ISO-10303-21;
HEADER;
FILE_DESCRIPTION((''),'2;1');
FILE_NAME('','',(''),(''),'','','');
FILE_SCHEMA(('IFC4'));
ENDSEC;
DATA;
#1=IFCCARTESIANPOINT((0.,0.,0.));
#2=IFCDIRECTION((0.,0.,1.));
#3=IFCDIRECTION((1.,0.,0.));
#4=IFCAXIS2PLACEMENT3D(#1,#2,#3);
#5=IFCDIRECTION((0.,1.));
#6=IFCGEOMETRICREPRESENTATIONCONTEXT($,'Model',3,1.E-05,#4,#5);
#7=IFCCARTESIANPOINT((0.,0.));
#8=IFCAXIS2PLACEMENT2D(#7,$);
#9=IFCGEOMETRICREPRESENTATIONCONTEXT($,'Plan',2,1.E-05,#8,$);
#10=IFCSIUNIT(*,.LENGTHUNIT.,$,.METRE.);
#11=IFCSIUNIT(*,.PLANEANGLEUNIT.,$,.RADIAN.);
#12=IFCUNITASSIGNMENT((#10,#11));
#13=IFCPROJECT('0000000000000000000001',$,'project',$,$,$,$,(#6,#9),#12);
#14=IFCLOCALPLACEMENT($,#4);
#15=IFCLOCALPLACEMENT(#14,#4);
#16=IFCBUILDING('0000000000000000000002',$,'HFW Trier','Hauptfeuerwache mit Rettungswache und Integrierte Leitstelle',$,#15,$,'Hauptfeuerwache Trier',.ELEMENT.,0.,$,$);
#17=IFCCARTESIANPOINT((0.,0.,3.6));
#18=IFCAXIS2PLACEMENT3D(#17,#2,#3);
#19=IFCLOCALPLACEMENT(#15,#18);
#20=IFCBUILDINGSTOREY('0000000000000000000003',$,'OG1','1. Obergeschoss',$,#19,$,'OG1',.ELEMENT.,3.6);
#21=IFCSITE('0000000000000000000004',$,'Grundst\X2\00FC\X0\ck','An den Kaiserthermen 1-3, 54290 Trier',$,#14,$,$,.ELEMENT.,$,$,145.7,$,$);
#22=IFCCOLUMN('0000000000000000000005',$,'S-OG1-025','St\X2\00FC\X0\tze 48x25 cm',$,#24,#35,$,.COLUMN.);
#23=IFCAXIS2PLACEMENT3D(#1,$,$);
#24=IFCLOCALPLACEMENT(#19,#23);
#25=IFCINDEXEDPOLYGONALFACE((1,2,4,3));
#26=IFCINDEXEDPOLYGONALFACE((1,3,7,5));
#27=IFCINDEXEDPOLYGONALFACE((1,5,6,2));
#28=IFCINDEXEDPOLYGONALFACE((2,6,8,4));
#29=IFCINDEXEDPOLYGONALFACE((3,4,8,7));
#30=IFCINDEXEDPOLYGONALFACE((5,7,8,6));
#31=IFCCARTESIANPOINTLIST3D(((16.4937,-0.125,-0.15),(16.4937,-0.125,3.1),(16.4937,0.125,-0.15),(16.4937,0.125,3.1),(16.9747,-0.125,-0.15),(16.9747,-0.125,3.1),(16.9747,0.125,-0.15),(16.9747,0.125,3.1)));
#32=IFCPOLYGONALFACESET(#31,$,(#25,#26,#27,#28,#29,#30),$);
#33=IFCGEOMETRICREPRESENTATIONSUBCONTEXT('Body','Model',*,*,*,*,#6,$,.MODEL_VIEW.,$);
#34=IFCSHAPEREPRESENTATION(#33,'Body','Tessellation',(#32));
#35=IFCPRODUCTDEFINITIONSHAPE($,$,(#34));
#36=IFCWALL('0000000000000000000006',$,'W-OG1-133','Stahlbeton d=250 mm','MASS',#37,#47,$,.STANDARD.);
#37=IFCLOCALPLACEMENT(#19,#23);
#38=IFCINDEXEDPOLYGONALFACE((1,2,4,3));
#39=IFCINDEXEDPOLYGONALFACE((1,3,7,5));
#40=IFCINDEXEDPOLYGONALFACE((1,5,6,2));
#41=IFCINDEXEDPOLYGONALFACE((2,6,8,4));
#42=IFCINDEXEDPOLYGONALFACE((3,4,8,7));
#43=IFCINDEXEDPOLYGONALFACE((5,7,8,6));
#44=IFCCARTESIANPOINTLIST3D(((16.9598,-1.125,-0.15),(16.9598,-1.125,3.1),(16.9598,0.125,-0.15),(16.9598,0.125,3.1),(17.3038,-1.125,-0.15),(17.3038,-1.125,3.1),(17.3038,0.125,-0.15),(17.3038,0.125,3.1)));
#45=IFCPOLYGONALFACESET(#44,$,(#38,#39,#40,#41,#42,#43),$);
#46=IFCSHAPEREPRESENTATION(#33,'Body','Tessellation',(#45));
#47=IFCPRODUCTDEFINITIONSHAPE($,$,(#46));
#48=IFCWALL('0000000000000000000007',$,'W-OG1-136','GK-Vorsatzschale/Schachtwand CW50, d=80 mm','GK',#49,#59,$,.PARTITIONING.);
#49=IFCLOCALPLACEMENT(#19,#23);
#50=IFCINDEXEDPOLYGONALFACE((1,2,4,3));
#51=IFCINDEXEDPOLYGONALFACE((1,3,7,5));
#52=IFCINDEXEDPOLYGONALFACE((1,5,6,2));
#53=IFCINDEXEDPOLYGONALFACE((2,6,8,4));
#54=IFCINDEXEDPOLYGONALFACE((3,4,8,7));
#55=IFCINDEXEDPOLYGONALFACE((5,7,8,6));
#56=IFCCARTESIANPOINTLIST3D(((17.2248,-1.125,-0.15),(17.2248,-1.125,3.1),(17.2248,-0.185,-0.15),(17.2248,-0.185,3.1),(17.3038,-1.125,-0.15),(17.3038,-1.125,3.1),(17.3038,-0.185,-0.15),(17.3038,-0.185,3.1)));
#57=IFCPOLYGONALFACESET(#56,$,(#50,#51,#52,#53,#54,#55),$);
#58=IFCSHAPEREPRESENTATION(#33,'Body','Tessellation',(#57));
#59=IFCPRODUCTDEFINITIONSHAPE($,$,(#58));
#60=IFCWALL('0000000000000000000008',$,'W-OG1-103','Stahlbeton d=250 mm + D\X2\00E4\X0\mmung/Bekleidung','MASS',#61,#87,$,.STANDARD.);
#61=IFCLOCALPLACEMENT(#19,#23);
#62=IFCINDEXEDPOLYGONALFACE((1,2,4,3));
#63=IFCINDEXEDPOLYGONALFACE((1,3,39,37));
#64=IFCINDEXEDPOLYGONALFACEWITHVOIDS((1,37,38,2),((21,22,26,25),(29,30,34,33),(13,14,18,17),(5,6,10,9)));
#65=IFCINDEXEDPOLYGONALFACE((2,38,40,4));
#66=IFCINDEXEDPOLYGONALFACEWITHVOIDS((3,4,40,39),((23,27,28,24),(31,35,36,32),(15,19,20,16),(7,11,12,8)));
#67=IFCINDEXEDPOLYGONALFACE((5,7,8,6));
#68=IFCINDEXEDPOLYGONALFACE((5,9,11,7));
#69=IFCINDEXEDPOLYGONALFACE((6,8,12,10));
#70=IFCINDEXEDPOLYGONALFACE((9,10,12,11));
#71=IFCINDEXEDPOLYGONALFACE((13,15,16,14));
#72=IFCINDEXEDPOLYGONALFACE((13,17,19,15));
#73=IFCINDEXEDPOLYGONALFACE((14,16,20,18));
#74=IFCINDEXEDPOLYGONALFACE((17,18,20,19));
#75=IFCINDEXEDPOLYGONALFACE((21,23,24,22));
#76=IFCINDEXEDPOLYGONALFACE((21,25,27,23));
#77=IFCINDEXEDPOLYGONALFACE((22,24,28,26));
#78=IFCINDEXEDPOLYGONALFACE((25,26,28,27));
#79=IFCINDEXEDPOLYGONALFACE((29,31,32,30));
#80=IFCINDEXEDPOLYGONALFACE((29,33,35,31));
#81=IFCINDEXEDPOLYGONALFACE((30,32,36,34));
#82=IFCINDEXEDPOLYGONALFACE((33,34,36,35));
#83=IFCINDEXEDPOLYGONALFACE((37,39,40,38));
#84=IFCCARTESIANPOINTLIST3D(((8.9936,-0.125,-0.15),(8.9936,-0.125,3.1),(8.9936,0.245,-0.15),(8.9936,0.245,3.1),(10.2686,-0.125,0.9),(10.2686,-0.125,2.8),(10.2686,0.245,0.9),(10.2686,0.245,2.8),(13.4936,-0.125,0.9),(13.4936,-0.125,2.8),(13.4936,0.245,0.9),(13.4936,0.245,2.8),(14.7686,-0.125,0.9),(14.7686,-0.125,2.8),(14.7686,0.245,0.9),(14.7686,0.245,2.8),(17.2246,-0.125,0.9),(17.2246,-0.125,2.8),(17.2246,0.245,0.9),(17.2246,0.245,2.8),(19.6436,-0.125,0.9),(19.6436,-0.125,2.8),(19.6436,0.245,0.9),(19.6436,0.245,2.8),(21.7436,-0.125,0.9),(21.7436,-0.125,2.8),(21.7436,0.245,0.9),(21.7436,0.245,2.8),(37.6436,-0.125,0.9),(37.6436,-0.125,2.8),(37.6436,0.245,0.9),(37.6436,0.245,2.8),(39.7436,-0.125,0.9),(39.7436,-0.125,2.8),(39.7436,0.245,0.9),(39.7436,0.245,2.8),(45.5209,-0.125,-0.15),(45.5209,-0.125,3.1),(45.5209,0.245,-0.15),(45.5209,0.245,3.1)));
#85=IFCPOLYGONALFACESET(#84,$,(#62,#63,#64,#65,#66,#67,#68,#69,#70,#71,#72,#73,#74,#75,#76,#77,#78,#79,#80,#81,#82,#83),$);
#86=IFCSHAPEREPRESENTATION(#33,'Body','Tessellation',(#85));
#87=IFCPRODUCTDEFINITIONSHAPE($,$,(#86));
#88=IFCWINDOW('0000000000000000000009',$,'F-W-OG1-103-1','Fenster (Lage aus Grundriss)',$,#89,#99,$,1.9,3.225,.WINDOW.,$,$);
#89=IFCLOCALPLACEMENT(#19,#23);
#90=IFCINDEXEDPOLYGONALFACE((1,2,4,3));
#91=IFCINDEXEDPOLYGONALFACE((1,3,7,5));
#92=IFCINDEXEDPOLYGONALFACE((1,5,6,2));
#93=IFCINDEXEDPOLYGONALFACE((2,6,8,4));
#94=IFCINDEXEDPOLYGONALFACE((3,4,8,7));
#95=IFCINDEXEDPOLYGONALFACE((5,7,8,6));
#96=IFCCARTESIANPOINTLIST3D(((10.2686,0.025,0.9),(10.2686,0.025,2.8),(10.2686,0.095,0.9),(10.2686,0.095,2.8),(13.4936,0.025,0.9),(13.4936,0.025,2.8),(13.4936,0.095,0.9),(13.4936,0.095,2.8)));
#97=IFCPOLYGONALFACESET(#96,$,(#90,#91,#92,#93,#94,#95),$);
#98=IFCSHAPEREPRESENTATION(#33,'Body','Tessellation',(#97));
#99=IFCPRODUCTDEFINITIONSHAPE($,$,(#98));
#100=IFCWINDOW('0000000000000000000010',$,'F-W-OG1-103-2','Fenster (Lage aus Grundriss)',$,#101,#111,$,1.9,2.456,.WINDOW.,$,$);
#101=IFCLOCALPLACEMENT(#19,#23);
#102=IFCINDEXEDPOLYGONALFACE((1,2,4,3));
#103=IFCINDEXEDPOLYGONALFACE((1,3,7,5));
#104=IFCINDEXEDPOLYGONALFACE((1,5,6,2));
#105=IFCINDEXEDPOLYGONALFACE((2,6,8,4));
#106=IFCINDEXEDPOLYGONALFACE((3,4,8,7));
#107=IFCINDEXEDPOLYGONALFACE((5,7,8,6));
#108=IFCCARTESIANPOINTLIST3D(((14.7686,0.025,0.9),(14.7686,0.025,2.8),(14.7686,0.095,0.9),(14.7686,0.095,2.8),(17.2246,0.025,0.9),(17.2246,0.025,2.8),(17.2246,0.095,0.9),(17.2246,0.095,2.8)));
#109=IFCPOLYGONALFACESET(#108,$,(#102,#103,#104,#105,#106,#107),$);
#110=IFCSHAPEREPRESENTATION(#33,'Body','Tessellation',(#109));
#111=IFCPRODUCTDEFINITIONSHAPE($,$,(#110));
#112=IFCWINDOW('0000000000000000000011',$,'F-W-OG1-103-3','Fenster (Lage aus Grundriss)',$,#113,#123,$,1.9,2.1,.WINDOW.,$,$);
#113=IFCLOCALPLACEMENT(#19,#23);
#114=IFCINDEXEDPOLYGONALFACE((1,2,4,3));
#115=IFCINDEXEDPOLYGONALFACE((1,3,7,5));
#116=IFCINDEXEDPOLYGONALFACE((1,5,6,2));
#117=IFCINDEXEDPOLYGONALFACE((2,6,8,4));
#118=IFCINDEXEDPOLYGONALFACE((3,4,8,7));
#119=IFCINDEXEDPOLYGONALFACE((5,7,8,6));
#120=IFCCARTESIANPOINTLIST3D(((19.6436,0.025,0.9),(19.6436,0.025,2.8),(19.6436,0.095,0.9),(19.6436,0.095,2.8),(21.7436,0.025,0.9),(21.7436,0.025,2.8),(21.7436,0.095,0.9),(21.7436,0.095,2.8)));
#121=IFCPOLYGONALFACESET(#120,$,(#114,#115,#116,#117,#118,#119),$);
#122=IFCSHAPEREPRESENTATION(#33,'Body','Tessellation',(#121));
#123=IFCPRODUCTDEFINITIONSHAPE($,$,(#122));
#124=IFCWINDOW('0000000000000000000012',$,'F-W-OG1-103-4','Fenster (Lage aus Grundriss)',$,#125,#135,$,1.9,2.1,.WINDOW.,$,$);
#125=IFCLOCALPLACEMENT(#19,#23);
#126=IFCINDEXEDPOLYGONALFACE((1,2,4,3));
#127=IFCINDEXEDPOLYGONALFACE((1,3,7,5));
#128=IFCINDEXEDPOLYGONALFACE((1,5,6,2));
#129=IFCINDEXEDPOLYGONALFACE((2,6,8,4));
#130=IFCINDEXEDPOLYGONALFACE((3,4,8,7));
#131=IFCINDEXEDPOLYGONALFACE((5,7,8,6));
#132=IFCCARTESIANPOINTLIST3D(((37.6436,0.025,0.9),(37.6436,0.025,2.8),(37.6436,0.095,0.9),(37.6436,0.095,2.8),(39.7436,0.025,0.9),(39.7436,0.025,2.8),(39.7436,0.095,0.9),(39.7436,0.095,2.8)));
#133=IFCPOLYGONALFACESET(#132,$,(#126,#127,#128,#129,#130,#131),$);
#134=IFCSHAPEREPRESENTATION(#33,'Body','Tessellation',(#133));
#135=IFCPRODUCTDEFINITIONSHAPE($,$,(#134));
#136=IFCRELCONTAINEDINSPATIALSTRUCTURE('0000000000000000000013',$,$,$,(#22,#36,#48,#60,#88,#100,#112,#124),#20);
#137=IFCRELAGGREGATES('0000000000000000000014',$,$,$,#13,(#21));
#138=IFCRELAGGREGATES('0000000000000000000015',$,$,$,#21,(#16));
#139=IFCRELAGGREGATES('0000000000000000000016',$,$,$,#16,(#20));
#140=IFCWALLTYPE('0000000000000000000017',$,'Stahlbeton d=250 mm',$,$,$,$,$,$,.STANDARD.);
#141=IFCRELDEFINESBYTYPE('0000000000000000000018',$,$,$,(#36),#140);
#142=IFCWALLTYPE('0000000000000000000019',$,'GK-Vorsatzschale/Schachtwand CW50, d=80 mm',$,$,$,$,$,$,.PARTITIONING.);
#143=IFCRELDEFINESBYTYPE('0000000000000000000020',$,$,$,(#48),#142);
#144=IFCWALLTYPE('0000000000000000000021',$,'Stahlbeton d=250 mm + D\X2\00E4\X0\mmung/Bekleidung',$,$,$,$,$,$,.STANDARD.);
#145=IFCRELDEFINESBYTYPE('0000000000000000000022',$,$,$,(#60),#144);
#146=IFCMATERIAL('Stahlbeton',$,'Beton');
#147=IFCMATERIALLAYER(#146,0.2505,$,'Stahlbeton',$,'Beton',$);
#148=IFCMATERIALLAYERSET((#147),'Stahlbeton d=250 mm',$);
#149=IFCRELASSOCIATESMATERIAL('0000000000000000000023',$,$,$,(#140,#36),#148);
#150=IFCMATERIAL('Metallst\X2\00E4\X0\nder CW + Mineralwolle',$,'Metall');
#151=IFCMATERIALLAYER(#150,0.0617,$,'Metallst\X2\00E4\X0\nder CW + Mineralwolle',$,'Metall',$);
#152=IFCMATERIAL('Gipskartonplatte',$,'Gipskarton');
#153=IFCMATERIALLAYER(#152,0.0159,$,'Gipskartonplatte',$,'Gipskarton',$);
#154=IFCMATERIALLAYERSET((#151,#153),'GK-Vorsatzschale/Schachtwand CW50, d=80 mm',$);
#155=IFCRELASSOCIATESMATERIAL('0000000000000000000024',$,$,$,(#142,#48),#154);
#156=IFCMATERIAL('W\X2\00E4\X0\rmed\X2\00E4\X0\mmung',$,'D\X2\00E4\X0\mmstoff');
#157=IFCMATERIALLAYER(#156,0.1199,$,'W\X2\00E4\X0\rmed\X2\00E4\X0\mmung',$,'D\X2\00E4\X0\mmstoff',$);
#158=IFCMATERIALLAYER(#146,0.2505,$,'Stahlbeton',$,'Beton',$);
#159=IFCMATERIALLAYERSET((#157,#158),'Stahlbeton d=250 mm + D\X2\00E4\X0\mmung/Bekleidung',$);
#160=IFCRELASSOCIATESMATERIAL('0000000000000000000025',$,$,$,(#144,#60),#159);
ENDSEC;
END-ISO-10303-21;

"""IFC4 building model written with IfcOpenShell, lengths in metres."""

from ifc_helpers import new_model, si_unit, direction, frame, frame_2d, origin_with_axes, origin_2d, place, context, subcontext, project, spatial, rectangle, extrude, material, layer, layer_set, layer_usage, type_object, element, fill, save


model = new_model("IFC4")

# Units and contexts
model_context = context("Model", 3, precision=1e-05, world=origin_with_axes(), true_north=direction((0.0, 1.0)))
plan_context = context("Plan", 2, precision=1e-05, world=origin_2d())
body_context = subcontext(model_context, "Body", "Model", "MODEL_VIEW")
ifc_project = project(units=[si_unit("LENGTHUNIT", "METRE"), si_unit("PLANEANGLEUNIT", "RADIAN")], contexts=[model_context, plan_context])

# Site, building, storey
site_placement = place(None, origin_with_axes())
site = spatial("IfcSite", under=ifc_project, at=site_placement, Name="Grundstück", Description="An den Kaiserthermen 1-3, 54290 Trier", CompositionType="ELEMENT", RefElevation=145.7)
building_placement = place(site_placement, origin_with_axes())
building = spatial("IfcBuilding", under=site, at=building_placement, Name="HFW Trier", Description="Hauptfeuerwache mit Rettungswache und Integrierte Leitstelle", LongName="Hauptfeuerwache Trier", CompositionType="ELEMENT", ElevationOfRefHeight=0.0)
storey_placement = place(building_placement, frame((0.0, 0.0, 3.6), z_axis=(0.0, 0.0, 1.0), x_axis=(1.0, 0.0, 0.0)))
storey = spatial("IfcBuildingStorey", under=building, at=storey_placement, Name="OG1", Description="1. Obergeschoss", LongName="OG1", CompositionType="ELEMENT", Elevation=3.6)

# Column
column_placement = place(storey_placement, frame((16.4937, 0.0, -0.15), z_axis=(0.0, 0.0, 1.0), x_axis=(1.0, 0.0, 0.0)))
element("IfcColumn", 1, at=column_placement, inside=storey, Name="S-OG1-025", Description="Stütze 48x25 cm", PredefinedType="COLUMN", context=body_context, shape_type="SweptSolid", body=[
    extrude(rectangle(XDim=0.481, YDim=0.25, at=frame_2d((0.2405, 0.0))), origin_with_axes(), (0.0, 0.0, 1.0), 3.25),
])

# Walls
ifc_material_1 = material(Name="Stahlbeton", Category="Beton")
ifc_layer_1 = layer(ifc_material_1, 0.2505, Name="Stahlbeton", Category="Beton")
ifc_layer_set_1 = layer_set([ifc_layer_1], Name="Stahlbeton d=250 mm")
ifc_layer_usage_1 = layer_usage(ifc_layer_set_1, "AXIS2", "POSITIVE", -0.172)
wall_type_1 = type_object("IfcWallType", Name="Stahlbeton d=250 mm", PredefinedType="STANDARD", material=ifc_layer_set_1)
wall_1_placement = place(storey_placement, frame((17.1318, 0.125, -0.15), z_axis=(0.0, 0.0, 1.0), x_axis=(0.0, -1.0, 0.0)))
element("IfcWall", 2, at=wall_1_placement, inside=storey, type_object=wall_type_1, material=ifc_layer_usage_1, Name="W-OG1-133", Description="Stahlbeton d=250 mm", ObjectType="MASS", PredefinedType="STANDARD", context=body_context, shape_type="SweptSolid", body=[
    extrude(rectangle(XDim=1.25, YDim=0.344, at=frame_2d((0.625, 0.0))), origin_with_axes(), (0.0, 0.0, 1.0), 3.25),
])
ifc_material_2 = material(Name="Metallständer CW + Mineralwolle", Category="Metall")
ifc_layer_2 = layer(ifc_material_2, 0.0617, Name="Metallständer CW + Mineralwolle", Category="Metall")
ifc_material_3 = material(Name="Gipskartonplatte", Category="Gipskarton")
ifc_layer_3 = layer(ifc_material_3, 0.0159, Name="Gipskartonplatte", Category="Gipskarton")
ifc_layer_set_2 = layer_set([ifc_layer_2, ifc_layer_3], Name="GK-Vorsatzschale/Schachtwand CW50, d=80 mm")
ifc_layer_usage_2 = layer_usage(ifc_layer_set_2, "AXIS2", "POSITIVE", -0.0395)
wall_type_2 = type_object("IfcWallType", Name="GK-Vorsatzschale/Schachtwand CW50, d=80 mm", PredefinedType="PARTITIONING", material=ifc_layer_set_2)
wall_2_placement = place(storey_placement, frame((17.2643, -0.185, -0.15), z_axis=(0.0, 0.0, 1.0), x_axis=(0.0, -1.0, 0.0)))
element("IfcWall", 3, at=wall_2_placement, inside=storey, type_object=wall_type_2, material=ifc_layer_usage_2, Name="W-OG1-136", Description="GK-Vorsatzschale/Schachtwand CW50, d=80 mm", ObjectType="GK", PredefinedType="PARTITIONING", context=body_context, shape_type="SweptSolid", body=[
    extrude(rectangle(XDim=0.94, YDim=0.079, at=frame_2d((0.47, 0.0))), origin_with_axes(), (0.0, 0.0, 1.0), 3.25),
])

# Wall, openings, windows
ifc_material_4 = material(Name="Wärmedämmung", Category="Dämmstoff")
ifc_layer_4 = layer(ifc_material_4, 0.1199, Name="Wärmedämmung", Category="Dämmstoff")
ifc_layer_5 = layer(ifc_material_1, 0.2505, Name="Stahlbeton", Category="Beton")
ifc_layer_set_3 = layer_set([ifc_layer_4, ifc_layer_5], Name="Stahlbeton d=250 mm + Dämmung/Bekleidung")
ifc_layer_usage_3 = layer_usage(ifc_layer_set_3, "AXIS2", "POSITIVE", -0.185)
wall_type_3 = type_object("IfcWallType", Name="Stahlbeton d=250 mm + Dämmung/Bekleidung", PredefinedType="STANDARD", material=ifc_layer_set_3)
wall_3_placement = place(storey_placement, frame((8.9936, 0.06, -0.15), z_axis=(0.0, 0.0, 1.0), x_axis=(1.0, 0.0, 0.0)))
wall_3 = element("IfcWall", 4, at=wall_3_placement, inside=storey, type_object=wall_type_3, material=ifc_layer_usage_3, Name="W-OG1-103", Description="Stahlbeton d=250 mm + Dämmung/Bekleidung", ObjectType="MASS", PredefinedType="STANDARD", context=body_context, shape_type="SweptSolid", body=[
    extrude(rectangle(XDim=36.5273, YDim=0.37, at=frame_2d((18.2636, 0.0))), origin_with_axes(), (0.0, 0.0, 1.0), 3.25),
])
opening_1_placement = place(wall_3_placement, frame((1.275, 0.0, 0.0), z_axis=(0.0, 0.0, 1.0), x_axis=(1.0, 0.0, 0.0)))
opening_1 = element("IfcOpeningElement", 5, at=opening_1_placement, cuts=wall_3, PredefinedType="OPENING", context=body_context, shape_type="SweptSolid", body=[
    extrude(rectangle(XDim=3.225, YDim=0.47, at=frame_2d((1.6125, 0.0))), frame((0.0, 0.0, 1.05), z_axis=(0.0, 0.0, 1.0), x_axis=(1.0, 0.0, 0.0)), (0.0, 0.0, 1.0), 1.9),
])
opening_2_placement = place(wall_3_placement, frame((5.775, 0.0, 0.0), z_axis=(0.0, 0.0, 1.0), x_axis=(1.0, 0.0, 0.0)))
opening_2 = element("IfcOpeningElement", 6, at=opening_2_placement, cuts=wall_3, PredefinedType="OPENING", context=body_context, shape_type="SweptSolid", body=[
    extrude(rectangle(XDim=2.456, YDim=0.47, at=frame_2d((1.228, 0.0))), frame((0.0, 0.0, 1.05), z_axis=(0.0, 0.0, 1.0), x_axis=(1.0, 0.0, 0.0)), (0.0, 0.0, 1.0), 1.9),
])
opening_3_placement = place(wall_3_placement, frame((10.65, 0.0, 0.0), z_axis=(0.0, 0.0, 1.0), x_axis=(1.0, 0.0, 0.0)))
opening_3 = element("IfcOpeningElement", 7, at=opening_3_placement, cuts=wall_3, PredefinedType="OPENING", context=body_context, shape_type="SweptSolid", body=[
    extrude(rectangle(XDim=2.1, YDim=0.47, at=frame_2d((1.05, 0.0))), frame((0.0, 0.0, 1.05), z_axis=(0.0, 0.0, 1.0), x_axis=(1.0, 0.0, 0.0)), (0.0, 0.0, 1.0), 1.9),
])
opening_4_placement = place(wall_3_placement, frame((28.65, 0.0, 0.0), z_axis=(0.0, 0.0, 1.0), x_axis=(1.0, 0.0, 0.0)))
opening_4 = element("IfcOpeningElement", 8, at=opening_4_placement, cuts=wall_3, PredefinedType="OPENING", context=body_context, shape_type="SweptSolid", body=[
    extrude(rectangle(XDim=2.1, YDim=0.47, at=frame_2d((1.05, 0.0))), frame((0.0, 0.0, 1.05), z_axis=(0.0, 0.0, 1.0), x_axis=(1.0, 0.0, 0.0)), (0.0, 0.0, 1.0), 1.9),
])
window_1_placement = place(wall_3_placement, frame((1.275, 0.0, 0.0), z_axis=(0.0, 0.0, 1.0), x_axis=(1.0, 0.0, 0.0)))
window_1 = element("IfcWindow", 9, at=window_1_placement, inside=storey, Name="F-W-OG1-103-1", Description="Fenster (Lage aus Grundriss)", OverallHeight=1.9, OverallWidth=3.225, PredefinedType="WINDOW", context=body_context, shape_type="SweptSolid", body=[
    extrude(rectangle(XDim=3.225, YDim=0.07, at=frame_2d((1.6125, 0.0))), frame((0.0, 0.0, 1.05), z_axis=(0.0, 0.0, 1.0), x_axis=(1.0, 0.0, 0.0)), (0.0, 0.0, 1.0), 1.9),
])
fill(opening_1, window_1)
window_2_placement = place(wall_3_placement, frame((5.775, 0.0, 0.0), z_axis=(0.0, 0.0, 1.0), x_axis=(1.0, 0.0, 0.0)))
window_2 = element("IfcWindow", 10, at=window_2_placement, inside=storey, Name="F-W-OG1-103-2", Description="Fenster (Lage aus Grundriss)", OverallHeight=1.9, OverallWidth=2.456, PredefinedType="WINDOW", context=body_context, shape_type="SweptSolid", body=[
    extrude(rectangle(XDim=2.456, YDim=0.07, at=frame_2d((1.228, 0.0))), frame((0.0, 0.0, 1.05), z_axis=(0.0, 0.0, 1.0), x_axis=(1.0, 0.0, 0.0)), (0.0, 0.0, 1.0), 1.9),
])
fill(opening_2, window_2)
window_3_placement = place(wall_3_placement, frame((10.65, 0.0, 0.0), z_axis=(0.0, 0.0, 1.0), x_axis=(1.0, 0.0, 0.0)))
window_3 = element("IfcWindow", 11, at=window_3_placement, inside=storey, Name="F-W-OG1-103-3", Description="Fenster (Lage aus Grundriss)", OverallHeight=1.9, OverallWidth=2.1, PredefinedType="WINDOW", context=body_context, shape_type="SweptSolid", body=[
    extrude(rectangle(XDim=2.1, YDim=0.07, at=frame_2d((1.05, 0.0))), frame((0.0, 0.0, 1.05), z_axis=(0.0, 0.0, 1.0), x_axis=(1.0, 0.0, 0.0)), (0.0, 0.0, 1.0), 1.9),
])
fill(opening_3, window_3)
window_4_placement = place(wall_3_placement, frame((28.65, 0.0, 0.0), z_axis=(0.0, 0.0, 1.0), x_axis=(1.0, 0.0, 0.0)))
window_4 = element("IfcWindow", 12, at=window_4_placement, inside=storey, Name="F-W-OG1-103-4", Description="Fenster (Lage aus Grundriss)", OverallHeight=1.9, OverallWidth=2.1, PredefinedType="WINDOW", context=body_context, shape_type="SweptSolid", body=[
    extrude(rectangle(XDim=2.1, YDim=0.07, at=frame_2d((1.05, 0.0))), frame((0.0, 0.0, 1.05), z_axis=(0.0, 0.0, 1.0), x_axis=(1.0, 0.0, 0.0)), (0.0, 0.0, 1.0), 1.9),
])
fill(opening_4, window_4)

save(model, "model.ifc")
